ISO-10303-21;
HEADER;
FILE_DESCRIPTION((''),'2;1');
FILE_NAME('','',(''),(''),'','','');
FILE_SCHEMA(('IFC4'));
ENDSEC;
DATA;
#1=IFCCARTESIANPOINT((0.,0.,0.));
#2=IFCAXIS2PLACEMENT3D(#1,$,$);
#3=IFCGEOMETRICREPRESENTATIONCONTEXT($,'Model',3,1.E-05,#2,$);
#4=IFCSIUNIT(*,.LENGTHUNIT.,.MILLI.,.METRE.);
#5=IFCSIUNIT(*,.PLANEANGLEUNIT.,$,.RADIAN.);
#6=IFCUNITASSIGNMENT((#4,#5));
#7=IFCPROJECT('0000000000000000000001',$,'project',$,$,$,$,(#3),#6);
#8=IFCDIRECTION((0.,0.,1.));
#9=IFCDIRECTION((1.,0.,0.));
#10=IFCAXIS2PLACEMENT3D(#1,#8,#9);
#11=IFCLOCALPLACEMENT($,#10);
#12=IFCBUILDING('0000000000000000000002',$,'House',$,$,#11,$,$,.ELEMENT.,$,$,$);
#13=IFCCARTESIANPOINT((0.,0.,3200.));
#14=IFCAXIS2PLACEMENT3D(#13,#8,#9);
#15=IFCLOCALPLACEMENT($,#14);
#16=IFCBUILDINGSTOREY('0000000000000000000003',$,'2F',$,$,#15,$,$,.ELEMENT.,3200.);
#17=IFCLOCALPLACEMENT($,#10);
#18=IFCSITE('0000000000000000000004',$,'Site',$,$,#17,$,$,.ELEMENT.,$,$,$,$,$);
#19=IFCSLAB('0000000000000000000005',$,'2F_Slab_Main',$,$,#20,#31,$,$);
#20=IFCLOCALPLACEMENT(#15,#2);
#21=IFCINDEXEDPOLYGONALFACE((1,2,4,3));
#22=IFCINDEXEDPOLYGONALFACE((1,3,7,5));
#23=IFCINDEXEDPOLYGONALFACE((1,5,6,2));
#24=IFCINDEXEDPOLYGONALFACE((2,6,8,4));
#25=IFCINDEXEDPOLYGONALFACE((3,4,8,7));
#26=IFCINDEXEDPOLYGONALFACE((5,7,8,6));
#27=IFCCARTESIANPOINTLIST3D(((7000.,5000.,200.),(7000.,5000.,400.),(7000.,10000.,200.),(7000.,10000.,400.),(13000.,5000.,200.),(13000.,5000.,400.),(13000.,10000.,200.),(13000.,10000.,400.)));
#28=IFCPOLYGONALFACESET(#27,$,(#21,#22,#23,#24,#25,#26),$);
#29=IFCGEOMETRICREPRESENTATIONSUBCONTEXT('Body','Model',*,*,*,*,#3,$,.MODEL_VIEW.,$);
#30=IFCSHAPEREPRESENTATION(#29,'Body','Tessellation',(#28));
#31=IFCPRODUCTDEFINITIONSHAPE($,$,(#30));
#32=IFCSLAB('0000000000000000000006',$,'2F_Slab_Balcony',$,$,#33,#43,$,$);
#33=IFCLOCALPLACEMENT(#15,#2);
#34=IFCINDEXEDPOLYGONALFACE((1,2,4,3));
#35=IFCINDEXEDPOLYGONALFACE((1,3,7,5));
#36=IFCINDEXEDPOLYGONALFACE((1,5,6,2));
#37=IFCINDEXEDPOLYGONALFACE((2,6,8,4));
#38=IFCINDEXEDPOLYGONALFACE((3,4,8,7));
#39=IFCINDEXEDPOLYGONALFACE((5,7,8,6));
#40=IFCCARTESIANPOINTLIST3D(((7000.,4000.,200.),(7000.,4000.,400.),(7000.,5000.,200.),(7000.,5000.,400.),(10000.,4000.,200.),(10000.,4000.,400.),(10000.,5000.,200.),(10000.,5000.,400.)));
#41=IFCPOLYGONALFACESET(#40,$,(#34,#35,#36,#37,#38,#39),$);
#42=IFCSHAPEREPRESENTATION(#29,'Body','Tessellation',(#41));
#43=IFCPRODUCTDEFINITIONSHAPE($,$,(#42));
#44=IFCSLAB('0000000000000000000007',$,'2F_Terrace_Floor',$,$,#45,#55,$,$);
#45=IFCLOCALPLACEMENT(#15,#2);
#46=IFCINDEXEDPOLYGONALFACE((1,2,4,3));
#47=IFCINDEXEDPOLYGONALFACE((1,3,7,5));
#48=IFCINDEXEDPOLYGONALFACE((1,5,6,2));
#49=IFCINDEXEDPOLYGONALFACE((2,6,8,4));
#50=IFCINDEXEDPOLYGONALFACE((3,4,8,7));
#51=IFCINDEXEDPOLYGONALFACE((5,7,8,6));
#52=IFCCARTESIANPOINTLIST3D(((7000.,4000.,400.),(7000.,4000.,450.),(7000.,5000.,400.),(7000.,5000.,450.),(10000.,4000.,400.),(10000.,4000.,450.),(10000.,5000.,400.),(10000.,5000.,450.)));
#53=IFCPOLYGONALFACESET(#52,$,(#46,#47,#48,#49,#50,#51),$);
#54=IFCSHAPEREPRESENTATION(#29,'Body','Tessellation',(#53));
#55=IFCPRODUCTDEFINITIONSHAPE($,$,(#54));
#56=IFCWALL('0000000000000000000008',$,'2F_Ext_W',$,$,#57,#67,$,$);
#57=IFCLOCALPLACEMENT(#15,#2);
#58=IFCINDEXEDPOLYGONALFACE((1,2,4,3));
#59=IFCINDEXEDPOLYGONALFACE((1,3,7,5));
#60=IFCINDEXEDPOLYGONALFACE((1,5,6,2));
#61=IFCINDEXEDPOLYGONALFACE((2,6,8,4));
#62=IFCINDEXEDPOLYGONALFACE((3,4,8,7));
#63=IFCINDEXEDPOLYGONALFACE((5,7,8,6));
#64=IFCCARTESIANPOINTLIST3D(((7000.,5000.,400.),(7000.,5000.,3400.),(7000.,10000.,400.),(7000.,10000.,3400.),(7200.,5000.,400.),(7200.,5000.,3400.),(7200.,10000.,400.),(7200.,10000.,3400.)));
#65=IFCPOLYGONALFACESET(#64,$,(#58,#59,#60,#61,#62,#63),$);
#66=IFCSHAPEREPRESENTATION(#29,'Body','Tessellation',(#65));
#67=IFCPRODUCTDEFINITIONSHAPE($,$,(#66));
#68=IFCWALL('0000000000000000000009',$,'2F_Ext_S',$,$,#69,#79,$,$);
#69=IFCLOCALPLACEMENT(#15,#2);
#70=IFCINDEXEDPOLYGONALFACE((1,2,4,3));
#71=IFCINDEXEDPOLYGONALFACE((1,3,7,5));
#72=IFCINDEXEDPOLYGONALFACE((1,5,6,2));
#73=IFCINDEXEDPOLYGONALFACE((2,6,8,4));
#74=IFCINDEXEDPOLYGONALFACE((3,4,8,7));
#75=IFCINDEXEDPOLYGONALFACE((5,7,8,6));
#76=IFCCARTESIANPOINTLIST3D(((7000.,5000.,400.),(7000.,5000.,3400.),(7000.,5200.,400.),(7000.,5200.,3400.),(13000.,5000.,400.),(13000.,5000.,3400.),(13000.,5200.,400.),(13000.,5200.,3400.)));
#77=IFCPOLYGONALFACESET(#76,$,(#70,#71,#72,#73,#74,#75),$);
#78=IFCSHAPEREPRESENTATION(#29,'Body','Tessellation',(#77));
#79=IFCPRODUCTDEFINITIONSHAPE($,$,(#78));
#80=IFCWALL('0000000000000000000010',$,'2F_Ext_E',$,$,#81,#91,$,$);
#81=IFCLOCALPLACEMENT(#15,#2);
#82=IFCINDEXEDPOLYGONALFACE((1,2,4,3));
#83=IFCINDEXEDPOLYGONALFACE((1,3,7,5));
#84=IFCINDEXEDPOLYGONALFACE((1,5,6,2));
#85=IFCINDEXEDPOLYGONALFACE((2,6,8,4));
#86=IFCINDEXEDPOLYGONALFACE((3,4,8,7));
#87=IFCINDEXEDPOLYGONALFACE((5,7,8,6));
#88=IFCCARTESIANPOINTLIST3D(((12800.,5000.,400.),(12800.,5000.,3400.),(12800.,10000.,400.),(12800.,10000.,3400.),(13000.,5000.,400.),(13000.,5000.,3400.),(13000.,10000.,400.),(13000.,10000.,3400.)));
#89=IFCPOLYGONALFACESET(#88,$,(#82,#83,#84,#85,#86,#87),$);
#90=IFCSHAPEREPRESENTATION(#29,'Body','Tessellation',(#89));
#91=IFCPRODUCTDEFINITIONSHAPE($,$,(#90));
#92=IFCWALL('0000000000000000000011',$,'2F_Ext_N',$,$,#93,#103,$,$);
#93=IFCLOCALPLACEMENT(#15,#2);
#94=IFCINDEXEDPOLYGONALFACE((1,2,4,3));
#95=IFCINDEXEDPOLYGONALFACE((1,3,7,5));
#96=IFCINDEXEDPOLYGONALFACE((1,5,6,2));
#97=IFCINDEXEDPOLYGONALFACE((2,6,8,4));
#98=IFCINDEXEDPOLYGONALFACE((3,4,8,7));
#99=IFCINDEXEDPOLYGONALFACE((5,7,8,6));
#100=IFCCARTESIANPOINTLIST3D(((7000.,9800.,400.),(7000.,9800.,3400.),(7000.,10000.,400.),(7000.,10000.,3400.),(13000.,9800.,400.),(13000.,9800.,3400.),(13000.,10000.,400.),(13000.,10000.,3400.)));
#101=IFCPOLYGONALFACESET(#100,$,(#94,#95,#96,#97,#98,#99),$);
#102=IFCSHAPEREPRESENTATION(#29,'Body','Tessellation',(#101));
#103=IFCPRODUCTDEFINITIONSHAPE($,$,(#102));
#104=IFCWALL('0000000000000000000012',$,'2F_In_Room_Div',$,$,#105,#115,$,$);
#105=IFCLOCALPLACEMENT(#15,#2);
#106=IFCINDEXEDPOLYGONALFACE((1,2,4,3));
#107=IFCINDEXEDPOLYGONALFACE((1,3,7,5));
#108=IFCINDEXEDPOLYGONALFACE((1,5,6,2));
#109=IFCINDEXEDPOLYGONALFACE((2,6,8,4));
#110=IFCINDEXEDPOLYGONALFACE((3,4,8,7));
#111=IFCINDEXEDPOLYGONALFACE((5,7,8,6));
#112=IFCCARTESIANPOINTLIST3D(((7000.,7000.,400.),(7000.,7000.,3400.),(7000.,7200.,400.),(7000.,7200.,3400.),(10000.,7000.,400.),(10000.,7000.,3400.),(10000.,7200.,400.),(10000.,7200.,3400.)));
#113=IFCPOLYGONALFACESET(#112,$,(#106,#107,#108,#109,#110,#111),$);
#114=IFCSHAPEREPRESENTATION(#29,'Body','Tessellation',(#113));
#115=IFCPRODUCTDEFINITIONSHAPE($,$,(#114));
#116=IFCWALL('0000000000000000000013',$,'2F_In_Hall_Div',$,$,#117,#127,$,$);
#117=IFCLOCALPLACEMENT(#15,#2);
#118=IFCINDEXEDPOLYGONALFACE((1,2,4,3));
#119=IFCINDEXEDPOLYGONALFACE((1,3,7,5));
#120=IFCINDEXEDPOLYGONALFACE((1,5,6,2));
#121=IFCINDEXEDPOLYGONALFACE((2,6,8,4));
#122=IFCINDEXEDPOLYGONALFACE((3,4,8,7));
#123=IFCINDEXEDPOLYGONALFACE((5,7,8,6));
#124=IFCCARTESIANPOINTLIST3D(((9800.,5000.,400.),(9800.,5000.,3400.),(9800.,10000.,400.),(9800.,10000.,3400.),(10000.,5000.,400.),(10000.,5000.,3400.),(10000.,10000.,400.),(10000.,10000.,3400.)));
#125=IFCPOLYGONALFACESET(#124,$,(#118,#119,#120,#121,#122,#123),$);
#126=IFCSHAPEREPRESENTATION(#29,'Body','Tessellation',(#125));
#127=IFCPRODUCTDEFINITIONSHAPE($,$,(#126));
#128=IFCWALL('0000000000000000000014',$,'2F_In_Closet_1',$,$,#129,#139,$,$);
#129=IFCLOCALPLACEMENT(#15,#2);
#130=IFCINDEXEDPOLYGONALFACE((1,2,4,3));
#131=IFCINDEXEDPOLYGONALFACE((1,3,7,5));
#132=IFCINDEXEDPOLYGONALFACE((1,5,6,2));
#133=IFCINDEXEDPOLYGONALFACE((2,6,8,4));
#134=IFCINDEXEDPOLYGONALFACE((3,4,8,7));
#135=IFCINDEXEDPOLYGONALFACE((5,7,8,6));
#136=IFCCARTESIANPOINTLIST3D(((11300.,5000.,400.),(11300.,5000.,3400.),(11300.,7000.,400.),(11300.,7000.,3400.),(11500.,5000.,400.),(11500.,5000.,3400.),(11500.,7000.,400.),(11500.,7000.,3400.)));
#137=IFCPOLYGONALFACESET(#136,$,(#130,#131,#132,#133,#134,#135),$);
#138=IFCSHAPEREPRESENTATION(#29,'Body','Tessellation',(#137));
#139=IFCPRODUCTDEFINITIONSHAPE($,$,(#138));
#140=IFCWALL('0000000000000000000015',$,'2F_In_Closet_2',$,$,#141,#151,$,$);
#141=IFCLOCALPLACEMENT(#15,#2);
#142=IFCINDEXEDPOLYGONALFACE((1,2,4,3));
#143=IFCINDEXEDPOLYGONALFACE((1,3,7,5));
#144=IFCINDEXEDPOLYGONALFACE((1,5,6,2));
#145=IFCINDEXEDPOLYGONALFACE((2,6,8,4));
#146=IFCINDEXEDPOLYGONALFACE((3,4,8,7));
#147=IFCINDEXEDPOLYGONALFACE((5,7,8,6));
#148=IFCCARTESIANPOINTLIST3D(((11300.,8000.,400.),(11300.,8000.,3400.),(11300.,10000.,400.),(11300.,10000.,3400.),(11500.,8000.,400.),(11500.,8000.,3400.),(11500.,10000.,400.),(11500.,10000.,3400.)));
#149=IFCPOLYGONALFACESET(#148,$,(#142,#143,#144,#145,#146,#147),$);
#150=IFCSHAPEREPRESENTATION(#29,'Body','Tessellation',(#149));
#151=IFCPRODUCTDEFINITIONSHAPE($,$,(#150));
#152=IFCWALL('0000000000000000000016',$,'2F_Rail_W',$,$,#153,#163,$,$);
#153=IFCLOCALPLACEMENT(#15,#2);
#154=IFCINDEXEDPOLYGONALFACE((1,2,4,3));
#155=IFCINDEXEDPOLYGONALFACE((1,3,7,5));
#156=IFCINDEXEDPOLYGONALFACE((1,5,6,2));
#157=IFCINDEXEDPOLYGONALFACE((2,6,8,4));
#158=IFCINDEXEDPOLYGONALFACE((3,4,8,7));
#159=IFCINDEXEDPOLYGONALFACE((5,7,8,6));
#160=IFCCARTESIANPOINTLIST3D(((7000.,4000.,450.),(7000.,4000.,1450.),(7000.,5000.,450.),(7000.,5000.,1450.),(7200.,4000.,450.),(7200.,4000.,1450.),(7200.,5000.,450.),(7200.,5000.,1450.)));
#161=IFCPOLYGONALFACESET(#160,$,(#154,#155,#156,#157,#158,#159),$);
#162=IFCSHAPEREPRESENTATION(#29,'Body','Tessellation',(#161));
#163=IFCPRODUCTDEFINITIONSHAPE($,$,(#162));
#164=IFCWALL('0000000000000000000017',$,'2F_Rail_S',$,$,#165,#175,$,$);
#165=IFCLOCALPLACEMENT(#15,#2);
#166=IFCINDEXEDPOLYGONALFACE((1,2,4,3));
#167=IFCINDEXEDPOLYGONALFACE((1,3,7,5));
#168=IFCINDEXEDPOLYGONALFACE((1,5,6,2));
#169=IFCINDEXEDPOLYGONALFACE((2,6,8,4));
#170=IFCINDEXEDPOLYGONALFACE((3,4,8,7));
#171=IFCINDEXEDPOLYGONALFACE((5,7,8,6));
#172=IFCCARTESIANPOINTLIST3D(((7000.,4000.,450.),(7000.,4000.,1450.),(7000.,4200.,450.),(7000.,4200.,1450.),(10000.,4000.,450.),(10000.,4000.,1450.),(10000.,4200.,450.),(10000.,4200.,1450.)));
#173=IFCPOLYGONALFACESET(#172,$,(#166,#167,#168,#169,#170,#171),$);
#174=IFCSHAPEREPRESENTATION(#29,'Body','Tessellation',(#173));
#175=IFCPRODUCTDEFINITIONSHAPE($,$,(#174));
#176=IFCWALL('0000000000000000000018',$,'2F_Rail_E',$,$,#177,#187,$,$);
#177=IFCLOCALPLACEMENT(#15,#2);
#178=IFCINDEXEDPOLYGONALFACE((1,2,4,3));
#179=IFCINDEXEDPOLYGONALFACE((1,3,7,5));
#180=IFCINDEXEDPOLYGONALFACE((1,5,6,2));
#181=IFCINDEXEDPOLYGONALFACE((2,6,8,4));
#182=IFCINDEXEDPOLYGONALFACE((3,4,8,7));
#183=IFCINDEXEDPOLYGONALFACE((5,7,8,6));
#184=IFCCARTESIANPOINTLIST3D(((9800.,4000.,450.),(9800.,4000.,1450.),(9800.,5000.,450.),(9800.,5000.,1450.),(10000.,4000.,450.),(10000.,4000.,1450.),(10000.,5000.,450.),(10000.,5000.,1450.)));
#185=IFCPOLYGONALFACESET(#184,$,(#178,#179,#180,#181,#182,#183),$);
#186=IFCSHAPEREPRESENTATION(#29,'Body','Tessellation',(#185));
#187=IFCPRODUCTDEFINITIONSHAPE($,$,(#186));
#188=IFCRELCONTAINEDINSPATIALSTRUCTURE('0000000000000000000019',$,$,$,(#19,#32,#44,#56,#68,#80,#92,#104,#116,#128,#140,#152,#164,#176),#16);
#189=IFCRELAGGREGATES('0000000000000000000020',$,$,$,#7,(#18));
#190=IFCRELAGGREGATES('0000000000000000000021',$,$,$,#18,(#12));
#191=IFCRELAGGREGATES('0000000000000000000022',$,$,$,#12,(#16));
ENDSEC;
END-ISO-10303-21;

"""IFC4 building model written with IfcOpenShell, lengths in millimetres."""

from ifc_helpers import new_model, si_unit, frame, origin, origin_with_axes, place, context, subcontext, project, spatial, rectangle, extrude, element, save


model = new_model("IFC4")

# Units and contexts
model_context = context("Model", 3, precision=1e-05, world=origin())
body_context = subcontext(model_context, "Body", "Model", "MODEL_VIEW")
ifc_project = project(units=[si_unit("LENGTHUNIT", "METRE", prefix="MILLI"), si_unit("PLANEANGLEUNIT", "RADIAN")], contexts=[model_context])

# Site, building, storey
site_placement = place(None, origin_with_axes())
site = spatial("IfcSite", under=ifc_project, at=site_placement, Name="Site", CompositionType="ELEMENT")
building_placement = place(None, origin_with_axes())
building = spatial("IfcBuilding", under=site, at=building_placement, Name="House", CompositionType="ELEMENT")
storey_placement = place(None, frame((0.0, 0.0, 3200.0), z_axis=(0.0, 0.0, 1.0), x_axis=(1.0, 0.0, 0.0)))
storey = spatial("IfcBuildingStorey", under=building, at=storey_placement, Name="2F", CompositionType="ELEMENT", Elevation=3200.0)

# Slabs
slab_1_placement = place(None, frame((7000.0, 5000.0, 3400.0), z_axis=(0.0, 0.0, 1.0), x_axis=(1.0, 0.0, 0.0)))
element("IfcSlab", 1, at=slab_1_placement, inside=storey, Name="2F_Slab_Main", context=body_context, shape_type="SweptSolid", body=[
    extrude(rectangle(XDim=6000.0, YDim=5000.0), frame((3000.0, 2500.0, 0.0)), (0.0, 0.0, 1.0), 200.0),
])
slab_2_placement = place(None, frame((7000.0, 4000.0, 3400.0), z_axis=(0.0, 0.0, 1.0), x_axis=(1.0, 0.0, 0.0)))
element("IfcSlab", 2, at=slab_2_placement, inside=storey, Name="2F_Slab_Balcony", context=body_context, shape_type="SweptSolid", body=[
    extrude(rectangle(XDim=3000.0, YDim=1000.0), frame((1500.0, 500.0, 0.0)), (0.0, 0.0, 1.0), 200.0),
])
slab_3_placement = place(None, frame((7000.0, 4000.0, 3600.0), z_axis=(0.0, 0.0, 1.0), x_axis=(1.0, 0.0, 0.0)))
element("IfcSlab", 3, at=slab_3_placement, inside=storey, Name="2F_Terrace_Floor", context=body_context, shape_type="SweptSolid", body=[
    extrude(rectangle(XDim=3000.0, YDim=1000.0), frame((1500.0, 500.0, 0.0)), (0.0, 0.0, 1.0), 50.0),
])

# Walls
wall_1_placement = place(None, frame((7000.0, 5000.0, 3600.0), z_axis=(0.0, 0.0, 1.0), x_axis=(1.0, 0.0, 0.0)))
element("IfcWall", 4, at=wall_1_placement, inside=storey, Name="2F_Ext_W", context=body_context, shape_type="SweptSolid", body=[
    extrude(rectangle(XDim=200.0, YDim=5000.0), frame((100.0, 2500.0, 0.0)), (0.0, 0.0, 1.0), 3000.0),
])
wall_2_placement = place(None, frame((7000.0, 5000.0, 3600.0), z_axis=(0.0, 0.0, 1.0), x_axis=(1.0, 0.0, 0.0)))
element("IfcWall", 5, at=wall_2_placement, inside=storey, Name="2F_Ext_S", context=body_context, shape_type="SweptSolid", body=[
    extrude(rectangle(XDim=6000.0, YDim=200.0), frame((3000.0, 100.0, 0.0)), (0.0, 0.0, 1.0), 3000.0),
])
wall_3_placement = place(None, frame((12800.0, 5000.0, 3600.0), z_axis=(0.0, 0.0, 1.0), x_axis=(1.0, 0.0, 0.0)))
element("IfcWall", 6, at=wall_3_placement, inside=storey, Name="2F_Ext_E", context=body_context, shape_type="SweptSolid", body=[
    extrude(rectangle(XDim=200.0, YDim=5000.0), frame((100.0, 2500.0, 0.0)), (0.0, 0.0, 1.0), 3000.0),
])
wall_4_placement = place(None, frame((7000.0, 9800.0, 3600.0), z_axis=(0.0, 0.0, 1.0), x_axis=(1.0, 0.0, 0.0)))
element("IfcWall", 7, at=wall_4_placement, inside=storey, Name="2F_Ext_N", context=body_context, shape_type="SweptSolid", body=[
    extrude(rectangle(XDim=6000.0, YDim=200.0), frame((3000.0, 100.0, 0.0)), (0.0, 0.0, 1.0), 3000.0),
])
wall_5_placement = place(None, frame((7000.0, 7000.0, 3600.0), z_axis=(0.0, 0.0, 1.0), x_axis=(1.0, 0.0, 0.0)))
element("IfcWall", 8, at=wall_5_placement, inside=storey, Name="2F_In_Room_Div", context=body_context, shape_type="SweptSolid", body=[
    extrude(rectangle(XDim=3000.0, YDim=200.0), frame((1500.0, 100.0, 0.0)), (0.0, 0.0, 1.0), 3000.0),
])
wall_6_placement = place(None, frame((9800.0, 5000.0, 3600.0), z_axis=(0.0, 0.0, 1.0), x_axis=(1.0, 0.0, 0.0)))
element("IfcWall", 9, at=wall_6_placement, inside=storey, Name="2F_In_Hall_Div", context=body_context, shape_type="SweptSolid", body=[
    extrude(rectangle(XDim=200.0, YDim=5000.0), frame((100.0, 2500.0, 0.0)), (0.0, 0.0, 1.0), 3000.0),
])
for number, where, z_axis, x_axis, name in (
    (10, (11300.0, 5000.0, 3600.0), (0.0, 0.0, 1.0), (1.0, 0.0, 0.0), "2F_In_Closet_1"),
    (11, (11300.0, 8000.0, 3600.0), (0.0, 0.0, 1.0), (1.0, 0.0, 0.0), "2F_In_Closet_2"),
):
    element("IfcWall", number, at=place(None, frame(where, z_axis=z_axis, x_axis=x_axis)), inside=storey, Name=name, context=body_context, shape_type="SweptSolid", body=[
        extrude(rectangle(XDim=200.0, YDim=2000.0), frame((100.0, 1000.0, 0.0)), (0.0, 0.0, 1.0), 3000.0),
    ])
wall_7_placement = place(None, frame((7000.0, 4000.0, 3650.0), z_axis=(0.0, 0.0, 1.0), x_axis=(1.0, 0.0, 0.0)))
element("IfcWall", 12, at=wall_7_placement, inside=storey, Name="2F_Rail_W", context=body_context, shape_type="SweptSolid", body=[
    extrude(rectangle(XDim=200.0, YDim=1000.0), frame((100.0, 500.0, 0.0)), (0.0, 0.0, 1.0), 1000.0),
])
wall_8_placement = place(None, frame((7000.0, 4000.0, 3650.0), z_axis=(0.0, 0.0, 1.0), x_axis=(1.0, 0.0, 0.0)))
element("IfcWall", 13, at=wall_8_placement, inside=storey, Name="2F_Rail_S", context=body_context, shape_type="SweptSolid", body=[
    extrude(rectangle(XDim=3000.0, YDim=200.0), frame((1500.0, 100.0, 0.0)), (0.0, 0.0, 1.0), 1000.0),
])
wall_9_placement = place(None, frame((9800.0, 4000.0, 3650.0), z_axis=(0.0, 0.0, 1.0), x_axis=(1.0, 0.0, 0.0)))
element("IfcWall", 14, at=wall_9_placement, inside=storey, Name="2F_Rail_E", context=body_context, shape_type="SweptSolid", body=[
    extrude(rectangle(XDim=200.0, YDim=1000.0), frame((100.0, 500.0, 0.0)), (0.0, 0.0, 1.0), 1000.0),
])

save(model, "model.ifc")
